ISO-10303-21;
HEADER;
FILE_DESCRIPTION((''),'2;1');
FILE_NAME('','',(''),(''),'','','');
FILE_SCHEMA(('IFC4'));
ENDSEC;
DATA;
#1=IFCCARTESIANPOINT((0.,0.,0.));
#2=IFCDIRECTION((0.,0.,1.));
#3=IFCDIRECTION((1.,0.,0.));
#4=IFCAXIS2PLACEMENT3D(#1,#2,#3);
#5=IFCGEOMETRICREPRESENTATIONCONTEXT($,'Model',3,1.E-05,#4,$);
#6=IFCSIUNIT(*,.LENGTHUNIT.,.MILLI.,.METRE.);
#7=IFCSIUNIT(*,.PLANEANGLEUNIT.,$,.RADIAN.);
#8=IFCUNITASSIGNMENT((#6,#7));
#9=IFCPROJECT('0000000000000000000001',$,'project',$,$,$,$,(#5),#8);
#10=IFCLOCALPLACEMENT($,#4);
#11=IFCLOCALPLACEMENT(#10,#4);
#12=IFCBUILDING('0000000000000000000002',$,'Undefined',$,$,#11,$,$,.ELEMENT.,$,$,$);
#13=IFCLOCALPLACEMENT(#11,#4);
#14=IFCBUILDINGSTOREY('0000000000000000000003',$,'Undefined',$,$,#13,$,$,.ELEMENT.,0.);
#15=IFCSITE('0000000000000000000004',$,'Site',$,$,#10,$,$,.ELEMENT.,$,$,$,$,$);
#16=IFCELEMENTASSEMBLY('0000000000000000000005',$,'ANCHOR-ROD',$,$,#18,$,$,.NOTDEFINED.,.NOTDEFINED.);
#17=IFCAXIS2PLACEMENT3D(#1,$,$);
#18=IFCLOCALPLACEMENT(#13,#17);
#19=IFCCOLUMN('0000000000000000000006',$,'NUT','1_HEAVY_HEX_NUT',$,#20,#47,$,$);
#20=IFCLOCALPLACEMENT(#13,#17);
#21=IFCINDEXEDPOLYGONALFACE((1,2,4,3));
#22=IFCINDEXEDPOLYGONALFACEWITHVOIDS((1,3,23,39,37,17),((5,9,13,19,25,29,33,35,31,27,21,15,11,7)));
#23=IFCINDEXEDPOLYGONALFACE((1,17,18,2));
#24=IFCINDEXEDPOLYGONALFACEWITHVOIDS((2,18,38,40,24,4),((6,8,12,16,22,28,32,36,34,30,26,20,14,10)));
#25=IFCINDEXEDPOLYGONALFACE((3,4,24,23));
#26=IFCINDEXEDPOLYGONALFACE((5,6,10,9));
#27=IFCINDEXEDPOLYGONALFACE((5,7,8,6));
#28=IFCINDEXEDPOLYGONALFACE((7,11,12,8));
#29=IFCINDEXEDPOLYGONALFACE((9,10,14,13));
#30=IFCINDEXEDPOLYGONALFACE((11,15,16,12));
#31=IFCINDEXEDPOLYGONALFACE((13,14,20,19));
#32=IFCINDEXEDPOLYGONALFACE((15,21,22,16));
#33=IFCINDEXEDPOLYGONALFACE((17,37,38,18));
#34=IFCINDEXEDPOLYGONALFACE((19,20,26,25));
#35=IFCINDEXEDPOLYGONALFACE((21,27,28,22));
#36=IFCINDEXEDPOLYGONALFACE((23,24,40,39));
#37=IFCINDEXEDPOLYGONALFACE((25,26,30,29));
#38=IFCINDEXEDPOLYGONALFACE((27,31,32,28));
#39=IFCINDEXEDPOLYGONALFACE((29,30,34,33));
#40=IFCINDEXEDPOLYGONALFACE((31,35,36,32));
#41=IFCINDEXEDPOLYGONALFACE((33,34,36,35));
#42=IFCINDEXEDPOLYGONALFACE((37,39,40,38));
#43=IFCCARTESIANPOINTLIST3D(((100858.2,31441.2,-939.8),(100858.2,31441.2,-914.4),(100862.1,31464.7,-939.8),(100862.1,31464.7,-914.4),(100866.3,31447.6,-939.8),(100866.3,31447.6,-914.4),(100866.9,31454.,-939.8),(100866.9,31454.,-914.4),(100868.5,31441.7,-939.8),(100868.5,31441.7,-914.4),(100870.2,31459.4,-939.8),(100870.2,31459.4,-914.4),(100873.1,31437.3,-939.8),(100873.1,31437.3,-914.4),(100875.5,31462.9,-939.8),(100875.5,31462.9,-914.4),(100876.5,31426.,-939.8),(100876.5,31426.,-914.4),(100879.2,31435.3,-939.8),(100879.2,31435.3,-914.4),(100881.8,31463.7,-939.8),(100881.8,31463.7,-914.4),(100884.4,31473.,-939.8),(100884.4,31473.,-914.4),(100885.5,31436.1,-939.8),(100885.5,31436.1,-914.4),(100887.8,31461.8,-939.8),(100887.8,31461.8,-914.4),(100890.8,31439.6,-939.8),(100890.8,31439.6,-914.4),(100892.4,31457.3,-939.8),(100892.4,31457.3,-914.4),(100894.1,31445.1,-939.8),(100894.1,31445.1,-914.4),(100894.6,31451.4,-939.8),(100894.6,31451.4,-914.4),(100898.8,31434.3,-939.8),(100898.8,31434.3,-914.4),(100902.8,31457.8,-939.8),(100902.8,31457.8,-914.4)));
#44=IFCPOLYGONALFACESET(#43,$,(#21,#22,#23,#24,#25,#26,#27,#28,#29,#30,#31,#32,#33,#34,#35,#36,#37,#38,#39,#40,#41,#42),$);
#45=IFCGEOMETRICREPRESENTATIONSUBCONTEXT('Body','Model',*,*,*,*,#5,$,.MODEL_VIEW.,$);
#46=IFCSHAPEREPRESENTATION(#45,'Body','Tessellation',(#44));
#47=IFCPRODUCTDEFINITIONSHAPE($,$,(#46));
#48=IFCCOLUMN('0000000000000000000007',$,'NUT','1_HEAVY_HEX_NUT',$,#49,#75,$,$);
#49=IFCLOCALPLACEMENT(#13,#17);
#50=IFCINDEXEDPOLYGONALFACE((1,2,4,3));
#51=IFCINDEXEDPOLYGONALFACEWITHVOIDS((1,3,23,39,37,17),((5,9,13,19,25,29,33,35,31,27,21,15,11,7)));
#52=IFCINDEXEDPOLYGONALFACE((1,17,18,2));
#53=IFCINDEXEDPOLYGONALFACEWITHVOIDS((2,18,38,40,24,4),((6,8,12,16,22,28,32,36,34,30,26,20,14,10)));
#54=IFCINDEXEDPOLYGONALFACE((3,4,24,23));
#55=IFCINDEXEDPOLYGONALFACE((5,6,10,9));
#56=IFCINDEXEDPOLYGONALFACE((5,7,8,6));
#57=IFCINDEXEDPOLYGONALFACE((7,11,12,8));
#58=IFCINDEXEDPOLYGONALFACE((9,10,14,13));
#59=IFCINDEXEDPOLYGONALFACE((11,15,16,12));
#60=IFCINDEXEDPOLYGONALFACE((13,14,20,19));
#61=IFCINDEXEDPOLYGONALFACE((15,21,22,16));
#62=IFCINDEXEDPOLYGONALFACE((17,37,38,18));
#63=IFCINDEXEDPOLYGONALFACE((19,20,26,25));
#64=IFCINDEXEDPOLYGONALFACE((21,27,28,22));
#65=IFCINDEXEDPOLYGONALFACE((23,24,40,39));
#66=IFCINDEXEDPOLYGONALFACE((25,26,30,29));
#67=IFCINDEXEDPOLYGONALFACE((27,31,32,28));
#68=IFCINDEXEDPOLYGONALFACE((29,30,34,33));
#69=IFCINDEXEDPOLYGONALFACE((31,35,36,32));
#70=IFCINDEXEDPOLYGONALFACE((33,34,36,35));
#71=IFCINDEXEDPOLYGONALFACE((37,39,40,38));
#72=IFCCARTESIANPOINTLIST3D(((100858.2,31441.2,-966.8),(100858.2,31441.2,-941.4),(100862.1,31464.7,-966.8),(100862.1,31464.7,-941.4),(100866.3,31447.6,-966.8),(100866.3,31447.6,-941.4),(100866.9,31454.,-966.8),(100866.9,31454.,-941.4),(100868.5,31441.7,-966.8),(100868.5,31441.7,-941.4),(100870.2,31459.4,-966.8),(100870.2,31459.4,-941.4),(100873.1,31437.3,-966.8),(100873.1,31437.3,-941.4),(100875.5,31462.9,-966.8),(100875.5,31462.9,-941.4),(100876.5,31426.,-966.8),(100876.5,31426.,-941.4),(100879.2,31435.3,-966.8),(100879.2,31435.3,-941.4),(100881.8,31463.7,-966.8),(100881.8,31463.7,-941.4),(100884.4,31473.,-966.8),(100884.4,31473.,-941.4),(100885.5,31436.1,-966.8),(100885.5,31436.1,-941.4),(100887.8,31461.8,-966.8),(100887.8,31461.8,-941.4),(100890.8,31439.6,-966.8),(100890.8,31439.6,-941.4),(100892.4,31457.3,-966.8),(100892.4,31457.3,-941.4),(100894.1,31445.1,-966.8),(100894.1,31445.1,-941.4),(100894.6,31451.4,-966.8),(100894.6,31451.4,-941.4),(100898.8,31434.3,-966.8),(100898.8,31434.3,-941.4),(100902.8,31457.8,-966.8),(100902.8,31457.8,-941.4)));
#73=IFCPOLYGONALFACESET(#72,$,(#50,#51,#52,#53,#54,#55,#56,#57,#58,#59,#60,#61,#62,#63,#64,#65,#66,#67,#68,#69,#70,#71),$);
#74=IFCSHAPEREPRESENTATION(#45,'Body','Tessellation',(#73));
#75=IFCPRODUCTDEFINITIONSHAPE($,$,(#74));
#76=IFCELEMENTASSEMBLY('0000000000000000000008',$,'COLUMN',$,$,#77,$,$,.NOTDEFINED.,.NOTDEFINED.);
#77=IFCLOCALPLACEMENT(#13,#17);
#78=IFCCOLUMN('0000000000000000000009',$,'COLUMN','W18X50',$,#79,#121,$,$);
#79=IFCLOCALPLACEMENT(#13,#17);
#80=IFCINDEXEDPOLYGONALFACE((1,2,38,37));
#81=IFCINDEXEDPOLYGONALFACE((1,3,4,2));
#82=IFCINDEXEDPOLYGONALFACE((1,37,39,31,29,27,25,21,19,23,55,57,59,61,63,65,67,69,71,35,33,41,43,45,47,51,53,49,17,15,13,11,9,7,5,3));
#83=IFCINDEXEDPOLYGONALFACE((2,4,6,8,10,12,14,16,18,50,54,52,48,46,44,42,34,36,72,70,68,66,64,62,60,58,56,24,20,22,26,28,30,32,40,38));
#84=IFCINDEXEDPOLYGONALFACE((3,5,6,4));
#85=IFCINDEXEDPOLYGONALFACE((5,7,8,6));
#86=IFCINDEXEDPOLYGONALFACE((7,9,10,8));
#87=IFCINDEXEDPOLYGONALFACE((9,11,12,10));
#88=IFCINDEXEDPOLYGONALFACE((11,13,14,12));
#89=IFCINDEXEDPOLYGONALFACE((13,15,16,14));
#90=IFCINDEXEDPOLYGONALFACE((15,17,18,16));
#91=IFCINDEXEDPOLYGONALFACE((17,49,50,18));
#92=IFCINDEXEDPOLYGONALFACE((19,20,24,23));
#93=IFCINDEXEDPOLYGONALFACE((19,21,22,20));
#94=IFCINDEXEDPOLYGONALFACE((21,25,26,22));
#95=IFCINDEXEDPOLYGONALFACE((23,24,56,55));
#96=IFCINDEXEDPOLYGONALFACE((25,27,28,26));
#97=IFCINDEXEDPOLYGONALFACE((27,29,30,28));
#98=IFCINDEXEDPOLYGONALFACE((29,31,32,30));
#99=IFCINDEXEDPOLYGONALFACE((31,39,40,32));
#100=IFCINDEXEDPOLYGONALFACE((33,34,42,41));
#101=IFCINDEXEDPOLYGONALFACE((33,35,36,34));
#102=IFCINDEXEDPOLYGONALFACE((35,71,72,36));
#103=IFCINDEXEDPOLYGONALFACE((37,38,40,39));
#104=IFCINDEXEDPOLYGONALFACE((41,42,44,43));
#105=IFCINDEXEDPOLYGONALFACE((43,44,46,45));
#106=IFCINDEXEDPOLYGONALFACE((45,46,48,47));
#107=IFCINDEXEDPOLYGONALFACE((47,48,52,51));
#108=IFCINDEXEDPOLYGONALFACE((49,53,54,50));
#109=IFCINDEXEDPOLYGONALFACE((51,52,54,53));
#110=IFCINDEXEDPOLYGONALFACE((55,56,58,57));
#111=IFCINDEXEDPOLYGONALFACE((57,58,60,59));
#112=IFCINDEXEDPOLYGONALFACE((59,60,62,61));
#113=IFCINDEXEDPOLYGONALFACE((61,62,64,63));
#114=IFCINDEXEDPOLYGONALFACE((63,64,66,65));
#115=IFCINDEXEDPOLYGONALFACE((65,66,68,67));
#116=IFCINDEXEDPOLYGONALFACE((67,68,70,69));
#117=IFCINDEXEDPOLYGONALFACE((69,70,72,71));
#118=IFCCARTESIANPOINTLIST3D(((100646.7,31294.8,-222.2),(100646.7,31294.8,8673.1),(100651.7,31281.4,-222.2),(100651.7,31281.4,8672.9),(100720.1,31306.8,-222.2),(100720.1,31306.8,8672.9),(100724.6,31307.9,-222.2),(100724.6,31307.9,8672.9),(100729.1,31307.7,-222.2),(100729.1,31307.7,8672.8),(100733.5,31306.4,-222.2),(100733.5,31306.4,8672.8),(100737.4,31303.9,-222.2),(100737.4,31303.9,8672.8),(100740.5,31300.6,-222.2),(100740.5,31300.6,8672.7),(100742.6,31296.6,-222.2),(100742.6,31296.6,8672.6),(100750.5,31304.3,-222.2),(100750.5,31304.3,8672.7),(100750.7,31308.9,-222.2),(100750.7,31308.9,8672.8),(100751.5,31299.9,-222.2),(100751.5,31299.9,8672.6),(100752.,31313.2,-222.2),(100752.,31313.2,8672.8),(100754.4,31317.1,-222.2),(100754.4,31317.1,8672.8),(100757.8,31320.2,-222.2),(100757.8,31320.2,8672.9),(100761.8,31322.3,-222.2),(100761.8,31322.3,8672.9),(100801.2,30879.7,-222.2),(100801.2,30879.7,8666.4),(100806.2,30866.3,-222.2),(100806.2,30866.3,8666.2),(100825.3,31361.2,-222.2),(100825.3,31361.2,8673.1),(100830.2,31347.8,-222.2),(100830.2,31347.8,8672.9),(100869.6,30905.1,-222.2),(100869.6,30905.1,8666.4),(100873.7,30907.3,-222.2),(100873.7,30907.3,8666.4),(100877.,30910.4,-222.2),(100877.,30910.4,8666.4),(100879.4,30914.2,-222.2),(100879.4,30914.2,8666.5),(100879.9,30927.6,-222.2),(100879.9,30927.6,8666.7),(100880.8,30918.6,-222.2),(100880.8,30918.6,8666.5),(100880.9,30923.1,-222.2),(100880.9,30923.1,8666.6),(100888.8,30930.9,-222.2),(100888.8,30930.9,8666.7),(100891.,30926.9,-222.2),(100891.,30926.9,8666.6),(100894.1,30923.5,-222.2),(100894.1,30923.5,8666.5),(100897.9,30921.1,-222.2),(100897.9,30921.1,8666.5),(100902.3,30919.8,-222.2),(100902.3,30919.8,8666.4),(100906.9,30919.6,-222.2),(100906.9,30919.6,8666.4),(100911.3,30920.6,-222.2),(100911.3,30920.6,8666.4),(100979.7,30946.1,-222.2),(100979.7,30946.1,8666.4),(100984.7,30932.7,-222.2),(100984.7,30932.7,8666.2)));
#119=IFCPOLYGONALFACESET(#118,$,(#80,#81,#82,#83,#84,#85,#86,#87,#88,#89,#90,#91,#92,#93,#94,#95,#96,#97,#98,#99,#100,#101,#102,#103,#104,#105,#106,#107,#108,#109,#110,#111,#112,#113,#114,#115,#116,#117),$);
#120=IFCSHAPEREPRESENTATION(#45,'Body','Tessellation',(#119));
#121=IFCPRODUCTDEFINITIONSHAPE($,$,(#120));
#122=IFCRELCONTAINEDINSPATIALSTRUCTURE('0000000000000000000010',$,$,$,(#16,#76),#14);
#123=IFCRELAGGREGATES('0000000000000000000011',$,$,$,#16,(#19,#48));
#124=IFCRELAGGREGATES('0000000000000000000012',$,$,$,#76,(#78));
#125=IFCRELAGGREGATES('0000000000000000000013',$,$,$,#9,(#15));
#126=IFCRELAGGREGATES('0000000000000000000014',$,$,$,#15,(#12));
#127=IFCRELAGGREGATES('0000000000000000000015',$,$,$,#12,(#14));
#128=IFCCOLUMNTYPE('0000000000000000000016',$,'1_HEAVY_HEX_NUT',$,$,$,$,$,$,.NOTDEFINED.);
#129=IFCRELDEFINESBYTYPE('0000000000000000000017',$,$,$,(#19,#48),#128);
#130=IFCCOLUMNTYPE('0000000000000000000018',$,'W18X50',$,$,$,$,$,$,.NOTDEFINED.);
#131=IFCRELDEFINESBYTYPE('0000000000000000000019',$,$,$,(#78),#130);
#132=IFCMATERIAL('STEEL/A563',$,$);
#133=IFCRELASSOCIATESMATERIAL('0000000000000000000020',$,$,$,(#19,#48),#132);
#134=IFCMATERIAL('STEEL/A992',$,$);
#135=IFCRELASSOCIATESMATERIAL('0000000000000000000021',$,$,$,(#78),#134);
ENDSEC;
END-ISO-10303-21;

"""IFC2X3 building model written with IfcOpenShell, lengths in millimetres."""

from ifc_helpers import new_model, si_unit, frame, origin_with_axes, origin_2d_with_axis, place, context, subcontext, project, spatial, polyline, i_section, outline, extrude, clip, halfspace, material, type_object, element, aggregate, save


model = new_model("IFC2X3")

# Units and contexts
model_context = context("Model", 3, precision=1e-05, world=origin_with_axes())
body_context = subcontext(model_context, "Body", "Model", "MODEL_VIEW")
ifc_project = project(units=[si_unit("LENGTHUNIT", "METRE", prefix="MILLI"), si_unit("PLANEANGLEUNIT", "RADIAN")], contexts=[model_context])

# Site, building, storey
site_placement = place(None, origin_with_axes())
site = spatial("IfcSite", under=ifc_project, at=site_placement, Name="Site", CompositionType="ELEMENT")
building_placement = place(site_placement, origin_with_axes())
building = spatial("IfcBuilding", under=site, at=building_placement, Name="Undefined", CompositionType="ELEMENT")
storey_placement = place(building_placement, origin_with_axes())
storey = spatial("IfcBuildingStorey", under=building, at=storey_placement, Name="Undefined", CompositionType="ELEMENT", Elevation=0.0)

# Element assembly, columns
ifc_material_1 = material(Name="STEEL/A563")
column_type_1 = type_object("IfcColumnType", Name="1_HEAVY_HEX_NUT", PredefinedType="NOTDEFINED")
assembly_1_placement = place(storey_placement, origin_with_axes())
assembly_1 = element("IfcElementAssembly", 1, at=assembly_1_placement, inside=storey, Name="ANCHOR-ROD", AssemblyPlace="NOTDEFINED", PredefinedType="NOTDEFINED")
column_1_placement = place(assembly_1_placement, frame((100880.5, 31449.5, -914.4), z_axis=(0.0, 0.0, -1.0), x_axis=(-0.34879, 0.937201, 0.0)))
column_1 = element("IfcColumn", 2, at=column_1_placement, type_object=column_type_1, material=ifc_material_1, Name="NUT", Description="1_HEAVY_HEX_NUT", context=body_context, shape_type="SweptSolid", body=[
    extrude(outline(polyline([(-11.9, -20.6), (-23.8, 0.0), (-11.9, 20.6), (11.9, 20.6), (23.8, 0.0), (11.9, -20.6), (-11.9, -20.6)]), holes=[polyline([(11.2, 8.9), (6.2, 12.9), (0.0, 14.3), (-6.2, 12.9), (-11.2, 8.9), (-13.9, 3.2), (-13.9, -3.2), (-11.2, -8.9), (-6.2, -12.9), (0.0, -14.3), (6.2, -12.9), (11.2, -8.9), (13.9, -3.2), (13.9, 3.2), (11.2, 8.9)])]), frame((0.0, 0.0, 25.4), z_axis=(0.0, 0.0, -1.0), x_axis=(0.0, 1.0, 0.0)), (0.0, 0.0, 1.0), 25.4),
])
column_2_placement = place(assembly_1_placement, frame((100880.5, 31449.5, -941.4), z_axis=(0.0, 0.0, -1.0), x_axis=(-0.34879, 0.937201, 0.0)))
column_2 = element("IfcColumn", 3, at=column_2_placement, type_object=column_type_1, material=ifc_material_1, Name="NUT", Description="1_HEAVY_HEX_NUT", context=body_context, shape_type="SweptSolid", body=[
    extrude(outline(polyline([(-11.9, -20.6), (-23.8, 0.0), (-11.9, 20.6), (11.9, 20.6), (23.8, 0.0), (11.9, -20.6), (-11.9, -20.6)]), holes=[polyline([(11.2, 8.9), (6.2, 12.9), (0.0, 14.3), (-6.2, 12.9), (-11.2, 8.9), (-13.9, 3.2), (-13.9, -3.2), (-11.2, -8.9), (-6.2, -12.9), (0.0, -14.3), (6.2, -12.9), (11.2, -8.9), (13.9, -3.2), (13.9, 3.2), (11.2, 8.9)])]), frame((0.0, 0.0, 25.4), z_axis=(0.0, 0.0, -1.0), x_axis=(0.0, 1.0, 0.0)), (0.0, 0.0, 1.0), 25.4),
])
aggregate(assembly_1, [column_1, column_2])

# Element assembly, column
assembly_2_placement = place(storey_placement, origin_with_axes())
assembly_2 = element("IfcElementAssembly", 4, at=assembly_2_placement, inside=storey, Name="COLUMN", AssemblyPlace="NOTDEFINED", PredefinedType="NOTDEFINED")
ifc_material_2 = material(Name="STEEL/A992")
column_type_2 = type_object("IfcColumnType", Name="W18X50", PredefinedType="NOTDEFINED")
column_3_placement = place(assembly_2_placement, frame((100815.7, 31113.7, -304.8), z_axis=(0.0, 0.0, 1.0), x_axis=(-0.34879, 0.937201, 0.0)))
column_3 = element("IfcColumn", 5, at=column_3_placement, type_object=column_type_2, material=ifc_material_2, Name="COLUMN", Description="W18X50", context=body_context, shape_type="Clipping", body=[
    clip(clip(extrude(i_section(OverallWidth=190.5, OverallDepth=457.2, WebThickness=9.5, FlangeThickness=14.3, FilletRadius=17.5, at=origin_2d_with_axis()), frame((0.0, 0.0, 9350.6), z_axis=(0.0, 0.0, -1.0), x_axis=(0.0, 1.0, 0.0)), (0.0, 0.0, 1.0), 9350.6), halfspace(frame((0.0, 95.3, 8974.4), z_axis=(0.01515, 0.0, -0.999885), x_axis=(-0.999885, 0.0, -0.01515)), True)), halfspace(frame((-228.6, 0.0, 82.6), z_axis=(0.0, 0.0, 1.0), x_axis=(0.0, 1.0, 0.0)), True)),
])
aggregate(assembly_2, [column_3])

save(model, "model.ifc")
